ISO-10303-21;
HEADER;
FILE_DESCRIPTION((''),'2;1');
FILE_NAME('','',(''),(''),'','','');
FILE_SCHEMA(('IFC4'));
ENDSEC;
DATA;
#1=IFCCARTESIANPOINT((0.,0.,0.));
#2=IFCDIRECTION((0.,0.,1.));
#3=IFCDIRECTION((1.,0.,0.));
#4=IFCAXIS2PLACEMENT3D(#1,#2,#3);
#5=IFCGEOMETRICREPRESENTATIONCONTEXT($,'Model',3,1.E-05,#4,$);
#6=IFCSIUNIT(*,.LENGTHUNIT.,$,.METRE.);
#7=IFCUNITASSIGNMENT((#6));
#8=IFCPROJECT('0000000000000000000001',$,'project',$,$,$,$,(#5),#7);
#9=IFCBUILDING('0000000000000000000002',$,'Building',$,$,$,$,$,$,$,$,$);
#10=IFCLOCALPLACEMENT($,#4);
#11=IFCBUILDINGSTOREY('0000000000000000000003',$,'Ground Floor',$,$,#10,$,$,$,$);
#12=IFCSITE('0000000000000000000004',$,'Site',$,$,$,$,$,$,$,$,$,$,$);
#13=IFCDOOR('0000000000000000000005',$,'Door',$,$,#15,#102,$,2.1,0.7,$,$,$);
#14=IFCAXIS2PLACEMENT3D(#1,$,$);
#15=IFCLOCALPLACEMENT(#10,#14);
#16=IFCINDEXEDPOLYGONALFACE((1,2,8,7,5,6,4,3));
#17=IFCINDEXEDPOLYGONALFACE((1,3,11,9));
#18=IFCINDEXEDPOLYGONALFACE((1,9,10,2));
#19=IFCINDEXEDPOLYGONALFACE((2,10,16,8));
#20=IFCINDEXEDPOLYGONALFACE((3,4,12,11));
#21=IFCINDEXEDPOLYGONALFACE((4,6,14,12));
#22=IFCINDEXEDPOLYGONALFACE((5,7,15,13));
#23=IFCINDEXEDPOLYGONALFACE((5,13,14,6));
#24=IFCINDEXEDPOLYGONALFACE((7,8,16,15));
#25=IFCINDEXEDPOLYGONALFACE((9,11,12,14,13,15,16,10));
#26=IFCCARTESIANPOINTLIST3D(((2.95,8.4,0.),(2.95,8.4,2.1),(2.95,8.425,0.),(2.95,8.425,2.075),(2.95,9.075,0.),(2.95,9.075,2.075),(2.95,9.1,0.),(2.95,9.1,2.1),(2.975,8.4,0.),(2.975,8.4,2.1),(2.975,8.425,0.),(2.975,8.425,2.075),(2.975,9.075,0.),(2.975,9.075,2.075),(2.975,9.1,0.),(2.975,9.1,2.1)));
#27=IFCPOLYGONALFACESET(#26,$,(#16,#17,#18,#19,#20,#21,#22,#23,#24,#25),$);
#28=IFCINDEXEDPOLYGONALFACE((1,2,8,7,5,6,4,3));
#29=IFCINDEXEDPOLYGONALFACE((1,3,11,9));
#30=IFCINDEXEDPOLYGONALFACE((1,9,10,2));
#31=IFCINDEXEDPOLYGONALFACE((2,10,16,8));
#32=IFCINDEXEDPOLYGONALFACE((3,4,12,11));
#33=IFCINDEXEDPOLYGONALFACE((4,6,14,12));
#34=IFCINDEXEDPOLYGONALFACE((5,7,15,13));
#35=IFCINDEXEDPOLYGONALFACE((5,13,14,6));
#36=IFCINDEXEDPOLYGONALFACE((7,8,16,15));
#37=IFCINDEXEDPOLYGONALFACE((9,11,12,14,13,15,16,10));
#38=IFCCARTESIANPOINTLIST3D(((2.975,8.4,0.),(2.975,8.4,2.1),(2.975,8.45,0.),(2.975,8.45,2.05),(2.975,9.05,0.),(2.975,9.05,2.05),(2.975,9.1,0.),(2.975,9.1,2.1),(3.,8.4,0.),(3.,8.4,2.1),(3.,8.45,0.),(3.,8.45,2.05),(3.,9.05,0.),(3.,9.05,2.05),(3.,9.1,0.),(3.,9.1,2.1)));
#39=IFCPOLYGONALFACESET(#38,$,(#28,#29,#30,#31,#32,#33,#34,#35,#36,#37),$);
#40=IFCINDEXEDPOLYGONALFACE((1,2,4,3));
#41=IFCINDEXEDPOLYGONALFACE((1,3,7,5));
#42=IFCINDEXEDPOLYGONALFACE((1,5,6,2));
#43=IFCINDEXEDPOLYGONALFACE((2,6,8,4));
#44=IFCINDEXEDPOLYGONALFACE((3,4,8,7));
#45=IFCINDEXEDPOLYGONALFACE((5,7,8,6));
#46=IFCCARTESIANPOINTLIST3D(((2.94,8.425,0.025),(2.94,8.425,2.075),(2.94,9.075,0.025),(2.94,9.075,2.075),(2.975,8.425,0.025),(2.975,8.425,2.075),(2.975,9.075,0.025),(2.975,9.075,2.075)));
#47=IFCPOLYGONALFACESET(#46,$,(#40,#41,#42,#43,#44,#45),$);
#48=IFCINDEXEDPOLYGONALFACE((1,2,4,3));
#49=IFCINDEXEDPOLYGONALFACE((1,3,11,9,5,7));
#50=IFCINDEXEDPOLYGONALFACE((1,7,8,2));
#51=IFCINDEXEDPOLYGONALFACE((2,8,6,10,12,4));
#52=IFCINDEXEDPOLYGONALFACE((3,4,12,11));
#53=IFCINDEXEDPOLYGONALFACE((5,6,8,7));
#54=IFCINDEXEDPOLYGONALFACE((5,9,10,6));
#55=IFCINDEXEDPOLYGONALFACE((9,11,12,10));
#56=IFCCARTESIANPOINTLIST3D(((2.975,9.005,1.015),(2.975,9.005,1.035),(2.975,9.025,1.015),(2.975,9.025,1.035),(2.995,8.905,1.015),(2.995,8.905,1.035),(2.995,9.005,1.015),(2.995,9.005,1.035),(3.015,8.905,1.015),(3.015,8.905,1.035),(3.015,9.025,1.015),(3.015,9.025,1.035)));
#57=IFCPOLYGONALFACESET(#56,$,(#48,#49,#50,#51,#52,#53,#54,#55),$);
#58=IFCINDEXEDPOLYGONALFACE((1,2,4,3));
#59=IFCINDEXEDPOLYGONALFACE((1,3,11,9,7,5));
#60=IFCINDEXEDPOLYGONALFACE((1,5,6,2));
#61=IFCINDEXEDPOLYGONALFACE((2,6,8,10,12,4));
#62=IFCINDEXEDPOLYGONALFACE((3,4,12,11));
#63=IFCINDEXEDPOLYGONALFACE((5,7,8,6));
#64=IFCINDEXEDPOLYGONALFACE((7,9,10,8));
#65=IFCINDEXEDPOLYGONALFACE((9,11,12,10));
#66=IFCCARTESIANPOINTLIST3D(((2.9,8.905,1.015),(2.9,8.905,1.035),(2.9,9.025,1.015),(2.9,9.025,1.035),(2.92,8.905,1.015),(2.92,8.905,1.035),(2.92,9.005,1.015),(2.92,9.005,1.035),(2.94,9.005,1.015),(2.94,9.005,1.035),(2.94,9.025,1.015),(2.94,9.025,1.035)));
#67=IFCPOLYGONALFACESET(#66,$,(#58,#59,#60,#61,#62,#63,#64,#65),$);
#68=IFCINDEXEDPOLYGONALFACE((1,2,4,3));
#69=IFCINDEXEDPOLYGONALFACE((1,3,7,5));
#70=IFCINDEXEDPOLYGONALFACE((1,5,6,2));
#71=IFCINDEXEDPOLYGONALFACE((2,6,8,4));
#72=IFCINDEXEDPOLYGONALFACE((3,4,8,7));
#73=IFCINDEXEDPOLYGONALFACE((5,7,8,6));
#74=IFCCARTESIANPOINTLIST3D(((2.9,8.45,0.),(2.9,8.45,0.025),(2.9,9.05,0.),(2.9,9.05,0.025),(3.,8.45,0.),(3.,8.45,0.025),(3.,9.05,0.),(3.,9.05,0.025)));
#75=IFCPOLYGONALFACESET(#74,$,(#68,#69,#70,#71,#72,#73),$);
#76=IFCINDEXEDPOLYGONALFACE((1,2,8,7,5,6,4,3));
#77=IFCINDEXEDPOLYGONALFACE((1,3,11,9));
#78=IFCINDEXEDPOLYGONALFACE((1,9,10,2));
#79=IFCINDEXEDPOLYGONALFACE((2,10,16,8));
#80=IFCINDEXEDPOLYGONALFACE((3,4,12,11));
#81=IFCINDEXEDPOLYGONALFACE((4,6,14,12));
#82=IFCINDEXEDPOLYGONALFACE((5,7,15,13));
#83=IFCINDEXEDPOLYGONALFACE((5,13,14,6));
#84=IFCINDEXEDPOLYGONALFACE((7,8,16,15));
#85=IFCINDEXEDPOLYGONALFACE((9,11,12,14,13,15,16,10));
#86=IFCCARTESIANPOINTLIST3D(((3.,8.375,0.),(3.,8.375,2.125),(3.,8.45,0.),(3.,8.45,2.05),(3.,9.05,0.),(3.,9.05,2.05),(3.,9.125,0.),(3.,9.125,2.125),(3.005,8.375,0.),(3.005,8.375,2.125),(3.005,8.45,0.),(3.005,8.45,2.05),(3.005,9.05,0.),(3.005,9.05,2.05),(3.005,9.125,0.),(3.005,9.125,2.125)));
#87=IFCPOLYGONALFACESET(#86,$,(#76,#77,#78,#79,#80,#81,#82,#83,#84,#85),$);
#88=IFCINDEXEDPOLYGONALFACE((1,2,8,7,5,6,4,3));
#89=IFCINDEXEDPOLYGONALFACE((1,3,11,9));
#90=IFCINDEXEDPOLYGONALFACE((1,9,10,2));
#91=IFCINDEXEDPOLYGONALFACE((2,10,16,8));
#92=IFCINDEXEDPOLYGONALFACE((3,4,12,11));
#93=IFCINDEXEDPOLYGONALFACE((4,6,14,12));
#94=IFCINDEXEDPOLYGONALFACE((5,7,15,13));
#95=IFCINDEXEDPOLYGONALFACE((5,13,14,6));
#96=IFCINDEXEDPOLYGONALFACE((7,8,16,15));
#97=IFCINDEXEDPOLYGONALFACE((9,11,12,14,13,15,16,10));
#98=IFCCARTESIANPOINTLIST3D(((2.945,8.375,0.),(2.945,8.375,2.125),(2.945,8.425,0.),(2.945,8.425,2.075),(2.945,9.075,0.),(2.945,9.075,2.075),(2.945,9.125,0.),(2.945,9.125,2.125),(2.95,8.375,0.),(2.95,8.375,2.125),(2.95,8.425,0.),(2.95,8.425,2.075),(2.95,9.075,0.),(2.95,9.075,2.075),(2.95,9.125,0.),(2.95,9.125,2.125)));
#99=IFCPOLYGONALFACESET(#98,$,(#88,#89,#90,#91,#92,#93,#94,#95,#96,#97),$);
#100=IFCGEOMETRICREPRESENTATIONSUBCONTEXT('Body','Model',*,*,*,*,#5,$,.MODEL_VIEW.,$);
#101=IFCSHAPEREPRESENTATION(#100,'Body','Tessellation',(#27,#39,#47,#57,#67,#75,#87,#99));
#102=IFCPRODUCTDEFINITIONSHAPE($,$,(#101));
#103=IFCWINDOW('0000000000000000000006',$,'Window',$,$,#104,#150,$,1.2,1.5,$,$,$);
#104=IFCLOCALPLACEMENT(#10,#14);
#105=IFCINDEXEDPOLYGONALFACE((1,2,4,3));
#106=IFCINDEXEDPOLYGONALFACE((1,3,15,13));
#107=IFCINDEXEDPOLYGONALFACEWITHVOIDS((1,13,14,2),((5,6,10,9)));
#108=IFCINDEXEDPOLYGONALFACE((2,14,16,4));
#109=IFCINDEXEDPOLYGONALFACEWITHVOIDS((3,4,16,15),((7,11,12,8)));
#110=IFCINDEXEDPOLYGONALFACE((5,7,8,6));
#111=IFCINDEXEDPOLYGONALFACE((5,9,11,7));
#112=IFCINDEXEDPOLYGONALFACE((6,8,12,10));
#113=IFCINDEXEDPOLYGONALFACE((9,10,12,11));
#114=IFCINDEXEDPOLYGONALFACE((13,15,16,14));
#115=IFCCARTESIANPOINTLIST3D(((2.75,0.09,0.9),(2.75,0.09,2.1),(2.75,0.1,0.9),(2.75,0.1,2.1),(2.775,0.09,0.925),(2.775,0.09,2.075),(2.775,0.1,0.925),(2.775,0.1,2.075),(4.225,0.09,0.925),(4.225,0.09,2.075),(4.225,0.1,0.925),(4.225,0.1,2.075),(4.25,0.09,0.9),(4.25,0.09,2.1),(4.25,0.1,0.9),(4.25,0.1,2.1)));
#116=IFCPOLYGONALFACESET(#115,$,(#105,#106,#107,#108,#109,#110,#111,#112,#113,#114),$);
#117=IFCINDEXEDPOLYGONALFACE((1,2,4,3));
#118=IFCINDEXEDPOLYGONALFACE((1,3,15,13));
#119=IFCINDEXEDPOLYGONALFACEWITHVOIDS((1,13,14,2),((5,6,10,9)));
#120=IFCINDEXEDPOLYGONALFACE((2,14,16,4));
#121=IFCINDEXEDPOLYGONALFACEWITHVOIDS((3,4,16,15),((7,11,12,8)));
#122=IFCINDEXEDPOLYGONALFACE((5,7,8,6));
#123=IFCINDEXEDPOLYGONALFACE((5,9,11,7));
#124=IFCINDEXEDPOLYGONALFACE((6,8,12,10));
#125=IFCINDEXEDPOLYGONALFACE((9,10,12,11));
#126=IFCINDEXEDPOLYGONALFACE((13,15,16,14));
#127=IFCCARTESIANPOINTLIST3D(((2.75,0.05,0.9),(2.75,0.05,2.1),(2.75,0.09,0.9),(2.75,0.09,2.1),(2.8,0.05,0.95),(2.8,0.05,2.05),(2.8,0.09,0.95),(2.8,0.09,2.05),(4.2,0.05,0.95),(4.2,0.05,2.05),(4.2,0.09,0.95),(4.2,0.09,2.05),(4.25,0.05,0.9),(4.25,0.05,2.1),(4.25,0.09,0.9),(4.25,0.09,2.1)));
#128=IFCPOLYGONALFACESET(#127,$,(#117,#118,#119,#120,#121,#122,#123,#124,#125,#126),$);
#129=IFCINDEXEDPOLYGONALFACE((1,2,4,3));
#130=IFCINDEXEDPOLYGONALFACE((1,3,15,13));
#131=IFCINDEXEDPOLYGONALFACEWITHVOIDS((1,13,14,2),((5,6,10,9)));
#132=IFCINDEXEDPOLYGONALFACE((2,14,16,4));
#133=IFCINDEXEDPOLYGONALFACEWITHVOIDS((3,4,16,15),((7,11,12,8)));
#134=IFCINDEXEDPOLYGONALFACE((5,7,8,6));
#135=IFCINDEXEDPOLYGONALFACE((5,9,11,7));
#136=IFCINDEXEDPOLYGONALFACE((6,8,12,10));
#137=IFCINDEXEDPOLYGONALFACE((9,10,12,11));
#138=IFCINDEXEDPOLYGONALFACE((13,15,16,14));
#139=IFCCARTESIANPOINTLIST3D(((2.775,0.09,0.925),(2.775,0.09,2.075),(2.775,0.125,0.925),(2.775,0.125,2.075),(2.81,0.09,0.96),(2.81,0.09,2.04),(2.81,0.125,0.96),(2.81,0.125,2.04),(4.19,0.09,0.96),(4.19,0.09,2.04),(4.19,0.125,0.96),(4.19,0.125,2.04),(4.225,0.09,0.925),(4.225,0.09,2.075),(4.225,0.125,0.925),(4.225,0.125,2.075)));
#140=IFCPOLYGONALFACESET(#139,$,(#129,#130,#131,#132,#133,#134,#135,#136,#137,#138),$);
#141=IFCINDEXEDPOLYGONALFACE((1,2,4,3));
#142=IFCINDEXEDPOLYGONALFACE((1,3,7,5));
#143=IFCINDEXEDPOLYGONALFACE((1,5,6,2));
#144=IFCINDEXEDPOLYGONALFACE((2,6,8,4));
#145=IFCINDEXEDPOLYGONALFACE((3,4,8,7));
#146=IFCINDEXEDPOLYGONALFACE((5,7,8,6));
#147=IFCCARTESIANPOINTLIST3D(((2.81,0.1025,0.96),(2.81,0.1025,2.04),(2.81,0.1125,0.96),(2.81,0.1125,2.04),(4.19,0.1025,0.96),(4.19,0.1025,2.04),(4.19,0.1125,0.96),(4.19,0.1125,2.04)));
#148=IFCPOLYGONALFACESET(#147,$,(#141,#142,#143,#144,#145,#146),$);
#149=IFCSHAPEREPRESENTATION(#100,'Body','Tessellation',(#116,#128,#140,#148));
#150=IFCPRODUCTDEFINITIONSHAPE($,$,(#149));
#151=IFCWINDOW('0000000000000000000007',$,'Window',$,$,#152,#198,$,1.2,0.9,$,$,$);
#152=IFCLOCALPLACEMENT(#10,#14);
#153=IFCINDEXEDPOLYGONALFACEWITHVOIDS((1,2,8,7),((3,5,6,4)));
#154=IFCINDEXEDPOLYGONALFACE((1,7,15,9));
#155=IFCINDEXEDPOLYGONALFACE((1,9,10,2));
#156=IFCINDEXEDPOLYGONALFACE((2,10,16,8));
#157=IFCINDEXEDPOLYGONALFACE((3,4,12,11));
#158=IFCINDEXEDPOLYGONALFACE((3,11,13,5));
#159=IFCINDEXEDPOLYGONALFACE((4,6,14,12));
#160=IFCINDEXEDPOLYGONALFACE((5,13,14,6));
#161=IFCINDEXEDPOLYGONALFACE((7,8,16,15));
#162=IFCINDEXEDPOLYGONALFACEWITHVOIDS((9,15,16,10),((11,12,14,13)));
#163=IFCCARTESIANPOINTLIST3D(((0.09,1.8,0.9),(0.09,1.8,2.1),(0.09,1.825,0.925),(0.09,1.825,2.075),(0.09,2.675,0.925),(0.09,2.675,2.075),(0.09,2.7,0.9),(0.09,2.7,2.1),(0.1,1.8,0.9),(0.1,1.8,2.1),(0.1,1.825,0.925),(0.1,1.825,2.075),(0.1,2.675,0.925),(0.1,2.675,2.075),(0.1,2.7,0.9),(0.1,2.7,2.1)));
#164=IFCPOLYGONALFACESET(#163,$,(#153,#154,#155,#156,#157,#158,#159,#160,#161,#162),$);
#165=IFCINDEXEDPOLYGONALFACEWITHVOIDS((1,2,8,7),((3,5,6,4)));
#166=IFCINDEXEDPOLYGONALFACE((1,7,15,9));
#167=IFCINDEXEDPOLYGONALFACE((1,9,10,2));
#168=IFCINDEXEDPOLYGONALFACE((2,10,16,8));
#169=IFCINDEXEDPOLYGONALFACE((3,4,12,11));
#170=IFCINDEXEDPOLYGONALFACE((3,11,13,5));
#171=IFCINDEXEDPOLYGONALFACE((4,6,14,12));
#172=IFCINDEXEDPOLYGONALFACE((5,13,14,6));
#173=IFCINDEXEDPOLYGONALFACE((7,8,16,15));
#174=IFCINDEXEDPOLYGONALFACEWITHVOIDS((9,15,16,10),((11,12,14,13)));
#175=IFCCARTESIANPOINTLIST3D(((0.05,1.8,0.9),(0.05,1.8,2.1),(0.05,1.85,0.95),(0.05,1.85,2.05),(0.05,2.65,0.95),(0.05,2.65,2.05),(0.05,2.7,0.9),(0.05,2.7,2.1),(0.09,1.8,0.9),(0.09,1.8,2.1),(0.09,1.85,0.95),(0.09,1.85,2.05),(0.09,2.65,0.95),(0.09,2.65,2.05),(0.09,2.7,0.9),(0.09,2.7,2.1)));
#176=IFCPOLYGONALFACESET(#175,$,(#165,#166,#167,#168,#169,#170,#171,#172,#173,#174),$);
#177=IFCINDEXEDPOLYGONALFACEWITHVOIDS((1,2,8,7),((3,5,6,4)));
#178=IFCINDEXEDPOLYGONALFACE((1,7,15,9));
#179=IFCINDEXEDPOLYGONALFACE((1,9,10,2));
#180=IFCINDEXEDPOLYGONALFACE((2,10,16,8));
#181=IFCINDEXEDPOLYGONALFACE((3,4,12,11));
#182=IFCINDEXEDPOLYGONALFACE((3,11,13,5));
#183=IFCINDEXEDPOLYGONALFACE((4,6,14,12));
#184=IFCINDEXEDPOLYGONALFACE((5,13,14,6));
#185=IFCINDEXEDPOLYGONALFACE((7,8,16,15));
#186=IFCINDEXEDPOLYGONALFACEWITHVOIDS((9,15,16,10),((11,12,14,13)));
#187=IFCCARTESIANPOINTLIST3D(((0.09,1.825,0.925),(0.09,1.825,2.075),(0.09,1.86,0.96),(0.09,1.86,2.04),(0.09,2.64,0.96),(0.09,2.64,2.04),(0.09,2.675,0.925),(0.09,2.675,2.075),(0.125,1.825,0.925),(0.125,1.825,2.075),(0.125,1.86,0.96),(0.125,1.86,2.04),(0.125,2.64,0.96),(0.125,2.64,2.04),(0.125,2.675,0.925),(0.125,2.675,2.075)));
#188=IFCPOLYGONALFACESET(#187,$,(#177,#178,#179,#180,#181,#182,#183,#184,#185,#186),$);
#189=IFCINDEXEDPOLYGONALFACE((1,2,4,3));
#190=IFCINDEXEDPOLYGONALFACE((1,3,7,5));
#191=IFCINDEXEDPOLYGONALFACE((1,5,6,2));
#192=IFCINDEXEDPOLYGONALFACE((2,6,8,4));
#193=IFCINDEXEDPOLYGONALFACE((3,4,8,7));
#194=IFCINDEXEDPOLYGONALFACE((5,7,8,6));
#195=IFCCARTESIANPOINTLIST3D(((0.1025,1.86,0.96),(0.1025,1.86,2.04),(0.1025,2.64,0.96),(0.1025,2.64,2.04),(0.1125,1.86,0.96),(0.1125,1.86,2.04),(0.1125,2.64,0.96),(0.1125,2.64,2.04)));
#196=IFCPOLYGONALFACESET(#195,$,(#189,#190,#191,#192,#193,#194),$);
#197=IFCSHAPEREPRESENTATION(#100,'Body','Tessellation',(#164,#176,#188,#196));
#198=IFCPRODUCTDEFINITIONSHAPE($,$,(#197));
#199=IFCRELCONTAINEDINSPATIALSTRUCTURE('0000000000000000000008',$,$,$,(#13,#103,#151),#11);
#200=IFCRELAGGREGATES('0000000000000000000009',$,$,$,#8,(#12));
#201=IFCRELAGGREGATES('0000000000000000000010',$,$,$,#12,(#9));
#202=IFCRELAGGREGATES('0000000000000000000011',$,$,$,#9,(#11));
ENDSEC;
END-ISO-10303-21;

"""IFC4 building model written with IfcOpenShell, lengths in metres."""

from ifc_helpers import new_model, si_unit, frame, origin_with_axes, place, context, subcontext, project, spatial, line, indexed_curve, outline, extrude, element, save


model = new_model("IFC4")

# Units and contexts
model_context = context("Model", 3, precision=1e-05, world=origin_with_axes())
body_context = subcontext(model_context, "Body", "Model", "MODEL_VIEW")
ifc_project = project(units=[si_unit("LENGTHUNIT", "METRE")], contexts=[model_context])

# Site, building, storey
site = spatial("IfcSite", under=ifc_project, Name="Site")
building = spatial("IfcBuilding", under=site, Name="Building")
storey_placement = place(None, origin_with_axes())
storey = spatial("IfcBuildingStorey", under=building, at=storey_placement, Name="Ground Floor")

# Door
door_1_placement = place(storey_placement, frame((3.0, 8.4, 0.0), z_axis=(0.0, 0.0, 1.0), x_axis=(0.0, 1.0, 0.0)))
element("IfcDoor", 1, at=door_1_placement, inside=storey, Name="Door", OverallHeight=2.1, OverallWidth=0.7, context=body_context, shape_type="SweptSolid", body=[
    extrude(outline(indexed_curve([(0.0, 0.0), (0.0, 2.1), (0.7, 2.1), (0.7, 0.0), (0.675, 0.0), (0.675, 2.075), (0.025, 2.075), (0.025, 0.0)], segments=[line(1, 2, 3, 4, 5, 6, 7, 8, 1)])), frame((0.0, 0.025, 0.0), z_axis=(0.0, -1.0, 0.0), x_axis=(1.0, 0.0, 0.0)), (0.0, 0.0, -1.0), 0.025),
    extrude(outline(indexed_curve([(0.0, 0.0), (0.0, 2.1), (0.7, 2.1), (0.7, 0.0), (0.65, 0.0), (0.65, 2.05), (0.05, 2.05), (0.05, 0.0)], segments=[line(1, 2, 3, 4, 5, 6, 7, 8, 1)])), frame((0.0, 0.0, 0.0), z_axis=(0.0, -1.0, 0.0), x_axis=(1.0, 0.0, 0.0)), (0.0, 0.0, -1.0), 0.025),
    extrude(outline(indexed_curve([(0.0, 0.0), (0.65, 0.0), (0.65, 0.035), (0.0, 0.035)], segments=[line(1, 2, 3, 4, 1)])), frame((0.025, 0.025, 0.025), z_axis=(0.0, 0.0, 1.0), x_axis=(1.0, 0.0, 0.0)), (0.0, 0.0, 1.0), 2.05),
    extrude(outline(indexed_curve([(0.0, 0.0), (0.0, -0.04), (-0.12, -0.04), (-0.12, -0.02), (-0.02, -0.02), (-0.02, 0.0)], segments=[line(1, 2, 3, 4, 5, 6, 1)])), frame((0.625, 0.025, 1.015), z_axis=(0.0, 0.0, 1.0), x_axis=(1.0, 0.0, 0.0)), (0.0, 0.0, 1.0), 0.02),
    extrude(outline(indexed_curve([(0.0, 0.0), (0.0, 0.04), (-0.12, 0.04), (-0.12, 0.02), (-0.02, 0.02), (-0.02, 0.0)], segments=[line(1, 2, 3, 4, 5, 6, 1)])), frame((0.625, 0.06, 1.015), z_axis=(0.0, 0.0, 1.0), x_axis=(1.0, 0.0, 0.0)), (0.0, 0.0, 1.0), 0.02),
    extrude(outline(indexed_curve([(0.0, 0.0), (0.6, 0.0), (0.6, 0.1), (0.0, 0.1)], segments=[line(1, 2, 3, 4, 1)])), frame((0.05, 0.0, 0.0), z_axis=(0.0, 0.0, 1.0), x_axis=(1.0, 0.0, 0.0)), (0.0, 0.0, 1.0), 0.025),
    extrude(outline(indexed_curve([(0.0, 0.0), (0.0, 2.125), (0.75, 2.125), (0.75, 0.0), (0.675, 0.0), (0.675, 2.05), (0.075, 2.05), (0.075, 0.0)], segments=[line(1, 2, 3, 4, 5, 6, 7, 8, 1)])), frame((-0.025, -0.005, 0.0), z_axis=(0.0, -1.0, 0.0), x_axis=(1.0, 0.0, 0.0)), (0.0, 0.0, -1.0), 0.005),
    extrude(outline(indexed_curve([(0.0, 0.0), (0.0, 2.125), (0.75, 2.125), (0.75, 0.0), (0.7, 0.0), (0.7, 2.075), (0.05, 2.075), (0.05, 0.0)], segments=[line(1, 2, 3, 4, 5, 6, 7, 8, 1)])), frame((-0.025, 0.05, 0.0), z_axis=(0.0, -1.0, 0.0), x_axis=(1.0, 0.0, 0.0)), (0.0, 0.0, -1.0), 0.005),
])

# Windows
window_placement = place(storey_placement, frame((2.75, 0.0, 0.9), z_axis=(0.0, 0.0, 1.0), x_axis=(1.0, 0.0, 0.0)))
element("IfcWindow", 2, at=window_placement, inside=storey, Name="Window", OverallHeight=1.2, OverallWidth=1.5, context=body_context, shape_type="SweptSolid", body=[
    extrude(outline(indexed_curve([(0.0, 0.0), (1.5, 0.0), (1.5, 1.2), (0.0, 1.2)], segments=[line(1, 2, 3, 4, 1)]), holes=[indexed_curve([(0.025, 0.025), (1.475, 0.025), (1.475, 1.175), (0.025, 1.175)], segments=[line(1, 2, 3, 4, 1)])]), frame((0.0, 0.09, 0.0), z_axis=(0.0, -1.0, 0.0), x_axis=(1.0, 0.0, 0.0)), (0.0, 0.0, -1.0), 0.01),
    extrude(outline(indexed_curve([(0.0, 0.0), (1.5, 0.0), (1.5, 1.2), (0.0, 1.2)], segments=[line(1, 2, 3, 4, 1)]), holes=[indexed_curve([(0.05, 0.05), (1.45, 0.05), (1.45, 1.15), (0.05, 1.15)], segments=[line(1, 2, 3, 4, 1)])]), frame((0.0, 0.05, 0.0), z_axis=(0.0, -1.0, 0.0), x_axis=(1.0, 0.0, 0.0)), (0.0, 0.0, -1.0), 0.04),
    extrude(outline(indexed_curve([(0.0, 0.0), (1.45, 0.0), (1.45, 1.15), (0.0, 1.15)], segments=[line(1, 2, 3, 4, 1)]), holes=[indexed_curve([(0.035, 0.035), (1.415, 0.035), (1.415, 1.115), (0.035, 1.115)], segments=[line(1, 2, 3, 4, 1)])]), frame((0.025, 0.09, 0.025), z_axis=(0.0, -1.0, 0.0), x_axis=(1.0, 0.0, 0.0)), (0.0, 0.0, -1.0), 0.035),
    extrude(outline(indexed_curve([(0.035, 0.035), (1.415, 0.035), (1.415, 1.115), (0.035, 1.115)], segments=[line(1, 2, 3, 4, 1)])), frame((0.025, 0.1025, 0.025), z_axis=(0.0, -1.0, 0.0), x_axis=(1.0, 0.0, 0.0)), (0.0, 0.0, -1.0), 0.01),
])
for number, where, z_axis, x_axis, name in (
    (3, (0.0, 2.7, 0.9), (0.0, 0.0, 1.0), (0.0, -1.0, 0.0), "Window"),
):
    element("IfcWindow", number, at=place(storey_placement, frame(where, z_axis=z_axis, x_axis=x_axis)), inside=storey, Name=name, OverallHeight=1.2, OverallWidth=0.9, context=body_context, shape_type="SweptSolid", body=[
        extrude(outline(indexed_curve([(0.0, 0.0), (0.9, 0.0), (0.9, 1.2), (0.0, 1.2)], segments=[line(1, 2, 3, 4, 1)]), holes=[indexed_curve([(0.025, 0.025), (0.875, 0.025), (0.875, 1.175), (0.025, 1.175)], segments=[line(1, 2, 3, 4, 1)])]), frame((0.0, 0.09, 0.0), z_axis=(0.0, -1.0, 0.0), x_axis=(1.0, 0.0, 0.0)), (0.0, 0.0, -1.0), 0.01),
        extrude(outline(indexed_curve([(0.0, 0.0), (0.9, 0.0), (0.9, 1.2), (0.0, 1.2)], segments=[line(1, 2, 3, 4, 1)]), holes=[indexed_curve([(0.05, 0.05), (0.85, 0.05), (0.85, 1.15), (0.05, 1.15)], segments=[line(1, 2, 3, 4, 1)])]), frame((0.0, 0.05, 0.0), z_axis=(0.0, -1.0, 0.0), x_axis=(1.0, 0.0, 0.0)), (0.0, 0.0, -1.0), 0.04),
        extrude(outline(indexed_curve([(0.0, 0.0), (0.85, 0.0), (0.85, 1.15), (0.0, 1.15)], segments=[line(1, 2, 3, 4, 1)]), holes=[indexed_curve([(0.035, 0.035), (0.815, 0.035), (0.815, 1.115), (0.035, 1.115)], segments=[line(1, 2, 3, 4, 1)])]), frame((0.025, 0.09, 0.025), z_axis=(0.0, -1.0, 0.0), x_axis=(1.0, 0.0, 0.0)), (0.0, 0.0, -1.0), 0.035),
        extrude(outline(indexed_curve([(0.035, 0.035), (0.815, 0.035), (0.815, 1.115), (0.035, 1.115)], segments=[line(1, 2, 3, 4, 1)])), frame((0.025, 0.1025, 0.025), z_axis=(0.0, -1.0, 0.0), x_axis=(1.0, 0.0, 0.0)), (0.0, 0.0, -1.0), 0.01),
    ])

save(model, "model.ifc")
